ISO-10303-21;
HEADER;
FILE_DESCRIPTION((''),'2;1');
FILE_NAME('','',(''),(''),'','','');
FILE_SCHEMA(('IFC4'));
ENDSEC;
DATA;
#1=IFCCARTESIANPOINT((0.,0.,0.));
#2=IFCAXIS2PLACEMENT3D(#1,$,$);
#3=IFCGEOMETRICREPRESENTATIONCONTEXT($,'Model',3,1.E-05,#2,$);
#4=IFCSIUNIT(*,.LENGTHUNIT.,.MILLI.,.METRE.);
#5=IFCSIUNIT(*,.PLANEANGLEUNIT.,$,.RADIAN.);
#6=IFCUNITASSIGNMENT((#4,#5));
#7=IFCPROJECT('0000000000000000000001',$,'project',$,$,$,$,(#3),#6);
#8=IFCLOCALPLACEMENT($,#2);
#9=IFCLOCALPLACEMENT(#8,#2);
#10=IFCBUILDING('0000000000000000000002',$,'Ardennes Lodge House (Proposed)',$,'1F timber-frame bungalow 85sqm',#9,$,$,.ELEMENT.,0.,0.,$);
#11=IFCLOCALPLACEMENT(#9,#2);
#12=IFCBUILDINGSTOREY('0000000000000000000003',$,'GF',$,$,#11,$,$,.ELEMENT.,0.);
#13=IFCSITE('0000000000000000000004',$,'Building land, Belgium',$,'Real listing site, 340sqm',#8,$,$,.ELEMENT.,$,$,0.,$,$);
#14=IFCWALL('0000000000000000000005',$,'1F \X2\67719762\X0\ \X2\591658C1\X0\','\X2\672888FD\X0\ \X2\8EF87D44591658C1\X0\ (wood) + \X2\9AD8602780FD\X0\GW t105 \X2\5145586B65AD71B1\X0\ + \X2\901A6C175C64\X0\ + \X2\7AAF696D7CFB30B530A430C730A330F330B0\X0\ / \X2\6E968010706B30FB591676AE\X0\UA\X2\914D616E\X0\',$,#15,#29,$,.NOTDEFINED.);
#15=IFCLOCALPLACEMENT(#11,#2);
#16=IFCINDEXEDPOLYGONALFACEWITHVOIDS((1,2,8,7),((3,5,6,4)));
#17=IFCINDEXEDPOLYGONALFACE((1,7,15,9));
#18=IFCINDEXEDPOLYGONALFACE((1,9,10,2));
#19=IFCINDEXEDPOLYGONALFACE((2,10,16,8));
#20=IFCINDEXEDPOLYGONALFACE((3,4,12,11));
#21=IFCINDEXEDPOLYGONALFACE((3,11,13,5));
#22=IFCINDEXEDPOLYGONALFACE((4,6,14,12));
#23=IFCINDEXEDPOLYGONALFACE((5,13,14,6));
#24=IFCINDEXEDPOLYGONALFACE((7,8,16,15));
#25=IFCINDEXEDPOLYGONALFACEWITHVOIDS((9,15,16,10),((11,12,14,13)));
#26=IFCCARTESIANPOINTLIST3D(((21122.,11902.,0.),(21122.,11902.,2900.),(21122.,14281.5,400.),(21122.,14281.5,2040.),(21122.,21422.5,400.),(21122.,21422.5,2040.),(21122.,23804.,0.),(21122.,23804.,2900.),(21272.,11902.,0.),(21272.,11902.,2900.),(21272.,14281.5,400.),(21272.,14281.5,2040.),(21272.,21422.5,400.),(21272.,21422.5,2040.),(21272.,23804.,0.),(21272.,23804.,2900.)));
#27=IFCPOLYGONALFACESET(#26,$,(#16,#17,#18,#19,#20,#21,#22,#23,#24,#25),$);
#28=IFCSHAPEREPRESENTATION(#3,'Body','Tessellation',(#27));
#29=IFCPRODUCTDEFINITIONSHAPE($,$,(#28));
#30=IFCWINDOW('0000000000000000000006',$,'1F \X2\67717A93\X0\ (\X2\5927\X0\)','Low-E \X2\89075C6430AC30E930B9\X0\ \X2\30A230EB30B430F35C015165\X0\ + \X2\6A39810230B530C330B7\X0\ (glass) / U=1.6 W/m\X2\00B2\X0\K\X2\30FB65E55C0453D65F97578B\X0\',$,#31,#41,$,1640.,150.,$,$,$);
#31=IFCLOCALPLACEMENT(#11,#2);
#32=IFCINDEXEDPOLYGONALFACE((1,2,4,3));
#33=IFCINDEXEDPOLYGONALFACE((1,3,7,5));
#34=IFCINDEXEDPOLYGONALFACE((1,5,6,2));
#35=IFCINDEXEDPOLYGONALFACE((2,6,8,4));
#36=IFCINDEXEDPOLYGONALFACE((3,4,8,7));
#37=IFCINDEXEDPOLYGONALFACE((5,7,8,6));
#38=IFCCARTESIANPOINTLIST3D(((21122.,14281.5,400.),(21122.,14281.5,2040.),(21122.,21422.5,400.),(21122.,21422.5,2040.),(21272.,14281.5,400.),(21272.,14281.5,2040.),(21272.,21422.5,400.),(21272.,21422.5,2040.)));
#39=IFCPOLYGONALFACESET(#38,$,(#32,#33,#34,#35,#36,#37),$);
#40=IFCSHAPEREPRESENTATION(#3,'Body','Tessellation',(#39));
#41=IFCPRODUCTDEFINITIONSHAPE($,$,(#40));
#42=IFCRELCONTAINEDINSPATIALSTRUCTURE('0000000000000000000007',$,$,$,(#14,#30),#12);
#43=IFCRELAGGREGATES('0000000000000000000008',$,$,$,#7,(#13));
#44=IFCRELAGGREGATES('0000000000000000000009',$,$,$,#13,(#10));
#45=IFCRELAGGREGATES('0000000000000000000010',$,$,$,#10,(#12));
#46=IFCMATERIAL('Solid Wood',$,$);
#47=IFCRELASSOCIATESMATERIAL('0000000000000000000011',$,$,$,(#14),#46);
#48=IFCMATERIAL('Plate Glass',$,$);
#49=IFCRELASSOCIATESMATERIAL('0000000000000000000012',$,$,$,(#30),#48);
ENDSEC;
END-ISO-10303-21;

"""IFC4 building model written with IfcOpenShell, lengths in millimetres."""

from ifc_helpers import new_model, si_unit, frame, frame_2d, origin, place, context, project, spatial, rectangle, extrude, material, element, fill, save


model = new_model("IFC4")

# Units and contexts
model_context = context("Model", 3, precision=1e-05, world=origin())
ifc_project = project(units=[si_unit("LENGTHUNIT", "METRE", prefix="MILLI"), si_unit("PLANEANGLEUNIT", "RADIAN")], contexts=[model_context])

# Site, building, storey
site_placement = place(None, origin())
site = spatial("IfcSite", under=ifc_project, at=site_placement, Name="Building land, Belgium", ObjectType="Real listing site, 340sqm", CompositionType="ELEMENT", RefElevation=0.0)
building_placement = place(site_placement, origin())
building = spatial("IfcBuilding", under=site, at=building_placement, Name="Ardennes Lodge House (Proposed)", ObjectType="1F timber-frame bungalow 85sqm", CompositionType="ELEMENT", ElevationOfRefHeight=0.0, ElevationOfTerrain=0.0)
storey_placement = place(building_placement, origin())
storey = spatial("IfcBuildingStorey", under=building, at=storey_placement, Name="GF", CompositionType="ELEMENT", Elevation=0.0)

# Shared definitions
ifc_material_1 = material(Name="Solid Wood")

# Shared definitions
ifc_material_2 = material(Name="Plate Glass")

# Wall, opening, window
wall_1_placement = place(storey_placement, frame((10561.0, 5951.0, 0.0)))
wall_1 = element("IfcWall", 1, at=wall_1_placement, inside=storey, material=ifc_material_1, Name="1F 東面 外壁", Description="木製 軸組外壁 (wood) + 高性能GW t105 充填断熱 + 通気層 + 窯業系サイディング / 準耐火・外皮UA配慮", PredefinedType="NOTDEFINED", context=model_context, shape_type="SweptSolid", body=[
    extrude(rectangle(XDim=150.0, YDim=11902.0, at=frame_2d((75.0, 5951.0))), frame((10561.0, 5951.0, 0.0)), (0.0, 0.0, 1.0), 2900.0),
])
opening_1_placement = place(storey_placement, frame((10561.0, 7141.0, 200.0)))
opening_1 = element("IfcOpeningElement", 2, at=opening_1_placement, cuts=wall_1, PredefinedType="NOTDEFINED", context=model_context, shape_type="SweptSolid", body=[
    extrude(rectangle(XDim=150.0, YDim=7141.0, at=frame_2d((75.0, 3570.0))), frame((10561.0, 7141.0, 200.0)), (0.0, 0.0, 1.0), 1640.0),
])
window_1_placement = place(storey_placement, frame((10561.0, 7141.0, 200.0)))
window_1 = element("IfcWindow", 3, at=window_1_placement, inside=storey, material=ifc_material_2, Name="1F 東窓 (大)", Description="Low-E 複層ガラス アルゴン封入 + 樹脂サッシ (glass) / U=1.6 W/m²K・日射取得型", OverallHeight=1640.0, OverallWidth=150.0, context=model_context, shape_type="SweptSolid", body=[
    extrude(rectangle(XDim=150.0, YDim=7141.0, at=frame_2d((75.0, 3570.0))), frame((10561.0, 7141.0, 200.0)), (0.0, 0.0, 1.0), 1640.0),
])
fill(opening_1, window_1)

save(model, "model.ifc")
